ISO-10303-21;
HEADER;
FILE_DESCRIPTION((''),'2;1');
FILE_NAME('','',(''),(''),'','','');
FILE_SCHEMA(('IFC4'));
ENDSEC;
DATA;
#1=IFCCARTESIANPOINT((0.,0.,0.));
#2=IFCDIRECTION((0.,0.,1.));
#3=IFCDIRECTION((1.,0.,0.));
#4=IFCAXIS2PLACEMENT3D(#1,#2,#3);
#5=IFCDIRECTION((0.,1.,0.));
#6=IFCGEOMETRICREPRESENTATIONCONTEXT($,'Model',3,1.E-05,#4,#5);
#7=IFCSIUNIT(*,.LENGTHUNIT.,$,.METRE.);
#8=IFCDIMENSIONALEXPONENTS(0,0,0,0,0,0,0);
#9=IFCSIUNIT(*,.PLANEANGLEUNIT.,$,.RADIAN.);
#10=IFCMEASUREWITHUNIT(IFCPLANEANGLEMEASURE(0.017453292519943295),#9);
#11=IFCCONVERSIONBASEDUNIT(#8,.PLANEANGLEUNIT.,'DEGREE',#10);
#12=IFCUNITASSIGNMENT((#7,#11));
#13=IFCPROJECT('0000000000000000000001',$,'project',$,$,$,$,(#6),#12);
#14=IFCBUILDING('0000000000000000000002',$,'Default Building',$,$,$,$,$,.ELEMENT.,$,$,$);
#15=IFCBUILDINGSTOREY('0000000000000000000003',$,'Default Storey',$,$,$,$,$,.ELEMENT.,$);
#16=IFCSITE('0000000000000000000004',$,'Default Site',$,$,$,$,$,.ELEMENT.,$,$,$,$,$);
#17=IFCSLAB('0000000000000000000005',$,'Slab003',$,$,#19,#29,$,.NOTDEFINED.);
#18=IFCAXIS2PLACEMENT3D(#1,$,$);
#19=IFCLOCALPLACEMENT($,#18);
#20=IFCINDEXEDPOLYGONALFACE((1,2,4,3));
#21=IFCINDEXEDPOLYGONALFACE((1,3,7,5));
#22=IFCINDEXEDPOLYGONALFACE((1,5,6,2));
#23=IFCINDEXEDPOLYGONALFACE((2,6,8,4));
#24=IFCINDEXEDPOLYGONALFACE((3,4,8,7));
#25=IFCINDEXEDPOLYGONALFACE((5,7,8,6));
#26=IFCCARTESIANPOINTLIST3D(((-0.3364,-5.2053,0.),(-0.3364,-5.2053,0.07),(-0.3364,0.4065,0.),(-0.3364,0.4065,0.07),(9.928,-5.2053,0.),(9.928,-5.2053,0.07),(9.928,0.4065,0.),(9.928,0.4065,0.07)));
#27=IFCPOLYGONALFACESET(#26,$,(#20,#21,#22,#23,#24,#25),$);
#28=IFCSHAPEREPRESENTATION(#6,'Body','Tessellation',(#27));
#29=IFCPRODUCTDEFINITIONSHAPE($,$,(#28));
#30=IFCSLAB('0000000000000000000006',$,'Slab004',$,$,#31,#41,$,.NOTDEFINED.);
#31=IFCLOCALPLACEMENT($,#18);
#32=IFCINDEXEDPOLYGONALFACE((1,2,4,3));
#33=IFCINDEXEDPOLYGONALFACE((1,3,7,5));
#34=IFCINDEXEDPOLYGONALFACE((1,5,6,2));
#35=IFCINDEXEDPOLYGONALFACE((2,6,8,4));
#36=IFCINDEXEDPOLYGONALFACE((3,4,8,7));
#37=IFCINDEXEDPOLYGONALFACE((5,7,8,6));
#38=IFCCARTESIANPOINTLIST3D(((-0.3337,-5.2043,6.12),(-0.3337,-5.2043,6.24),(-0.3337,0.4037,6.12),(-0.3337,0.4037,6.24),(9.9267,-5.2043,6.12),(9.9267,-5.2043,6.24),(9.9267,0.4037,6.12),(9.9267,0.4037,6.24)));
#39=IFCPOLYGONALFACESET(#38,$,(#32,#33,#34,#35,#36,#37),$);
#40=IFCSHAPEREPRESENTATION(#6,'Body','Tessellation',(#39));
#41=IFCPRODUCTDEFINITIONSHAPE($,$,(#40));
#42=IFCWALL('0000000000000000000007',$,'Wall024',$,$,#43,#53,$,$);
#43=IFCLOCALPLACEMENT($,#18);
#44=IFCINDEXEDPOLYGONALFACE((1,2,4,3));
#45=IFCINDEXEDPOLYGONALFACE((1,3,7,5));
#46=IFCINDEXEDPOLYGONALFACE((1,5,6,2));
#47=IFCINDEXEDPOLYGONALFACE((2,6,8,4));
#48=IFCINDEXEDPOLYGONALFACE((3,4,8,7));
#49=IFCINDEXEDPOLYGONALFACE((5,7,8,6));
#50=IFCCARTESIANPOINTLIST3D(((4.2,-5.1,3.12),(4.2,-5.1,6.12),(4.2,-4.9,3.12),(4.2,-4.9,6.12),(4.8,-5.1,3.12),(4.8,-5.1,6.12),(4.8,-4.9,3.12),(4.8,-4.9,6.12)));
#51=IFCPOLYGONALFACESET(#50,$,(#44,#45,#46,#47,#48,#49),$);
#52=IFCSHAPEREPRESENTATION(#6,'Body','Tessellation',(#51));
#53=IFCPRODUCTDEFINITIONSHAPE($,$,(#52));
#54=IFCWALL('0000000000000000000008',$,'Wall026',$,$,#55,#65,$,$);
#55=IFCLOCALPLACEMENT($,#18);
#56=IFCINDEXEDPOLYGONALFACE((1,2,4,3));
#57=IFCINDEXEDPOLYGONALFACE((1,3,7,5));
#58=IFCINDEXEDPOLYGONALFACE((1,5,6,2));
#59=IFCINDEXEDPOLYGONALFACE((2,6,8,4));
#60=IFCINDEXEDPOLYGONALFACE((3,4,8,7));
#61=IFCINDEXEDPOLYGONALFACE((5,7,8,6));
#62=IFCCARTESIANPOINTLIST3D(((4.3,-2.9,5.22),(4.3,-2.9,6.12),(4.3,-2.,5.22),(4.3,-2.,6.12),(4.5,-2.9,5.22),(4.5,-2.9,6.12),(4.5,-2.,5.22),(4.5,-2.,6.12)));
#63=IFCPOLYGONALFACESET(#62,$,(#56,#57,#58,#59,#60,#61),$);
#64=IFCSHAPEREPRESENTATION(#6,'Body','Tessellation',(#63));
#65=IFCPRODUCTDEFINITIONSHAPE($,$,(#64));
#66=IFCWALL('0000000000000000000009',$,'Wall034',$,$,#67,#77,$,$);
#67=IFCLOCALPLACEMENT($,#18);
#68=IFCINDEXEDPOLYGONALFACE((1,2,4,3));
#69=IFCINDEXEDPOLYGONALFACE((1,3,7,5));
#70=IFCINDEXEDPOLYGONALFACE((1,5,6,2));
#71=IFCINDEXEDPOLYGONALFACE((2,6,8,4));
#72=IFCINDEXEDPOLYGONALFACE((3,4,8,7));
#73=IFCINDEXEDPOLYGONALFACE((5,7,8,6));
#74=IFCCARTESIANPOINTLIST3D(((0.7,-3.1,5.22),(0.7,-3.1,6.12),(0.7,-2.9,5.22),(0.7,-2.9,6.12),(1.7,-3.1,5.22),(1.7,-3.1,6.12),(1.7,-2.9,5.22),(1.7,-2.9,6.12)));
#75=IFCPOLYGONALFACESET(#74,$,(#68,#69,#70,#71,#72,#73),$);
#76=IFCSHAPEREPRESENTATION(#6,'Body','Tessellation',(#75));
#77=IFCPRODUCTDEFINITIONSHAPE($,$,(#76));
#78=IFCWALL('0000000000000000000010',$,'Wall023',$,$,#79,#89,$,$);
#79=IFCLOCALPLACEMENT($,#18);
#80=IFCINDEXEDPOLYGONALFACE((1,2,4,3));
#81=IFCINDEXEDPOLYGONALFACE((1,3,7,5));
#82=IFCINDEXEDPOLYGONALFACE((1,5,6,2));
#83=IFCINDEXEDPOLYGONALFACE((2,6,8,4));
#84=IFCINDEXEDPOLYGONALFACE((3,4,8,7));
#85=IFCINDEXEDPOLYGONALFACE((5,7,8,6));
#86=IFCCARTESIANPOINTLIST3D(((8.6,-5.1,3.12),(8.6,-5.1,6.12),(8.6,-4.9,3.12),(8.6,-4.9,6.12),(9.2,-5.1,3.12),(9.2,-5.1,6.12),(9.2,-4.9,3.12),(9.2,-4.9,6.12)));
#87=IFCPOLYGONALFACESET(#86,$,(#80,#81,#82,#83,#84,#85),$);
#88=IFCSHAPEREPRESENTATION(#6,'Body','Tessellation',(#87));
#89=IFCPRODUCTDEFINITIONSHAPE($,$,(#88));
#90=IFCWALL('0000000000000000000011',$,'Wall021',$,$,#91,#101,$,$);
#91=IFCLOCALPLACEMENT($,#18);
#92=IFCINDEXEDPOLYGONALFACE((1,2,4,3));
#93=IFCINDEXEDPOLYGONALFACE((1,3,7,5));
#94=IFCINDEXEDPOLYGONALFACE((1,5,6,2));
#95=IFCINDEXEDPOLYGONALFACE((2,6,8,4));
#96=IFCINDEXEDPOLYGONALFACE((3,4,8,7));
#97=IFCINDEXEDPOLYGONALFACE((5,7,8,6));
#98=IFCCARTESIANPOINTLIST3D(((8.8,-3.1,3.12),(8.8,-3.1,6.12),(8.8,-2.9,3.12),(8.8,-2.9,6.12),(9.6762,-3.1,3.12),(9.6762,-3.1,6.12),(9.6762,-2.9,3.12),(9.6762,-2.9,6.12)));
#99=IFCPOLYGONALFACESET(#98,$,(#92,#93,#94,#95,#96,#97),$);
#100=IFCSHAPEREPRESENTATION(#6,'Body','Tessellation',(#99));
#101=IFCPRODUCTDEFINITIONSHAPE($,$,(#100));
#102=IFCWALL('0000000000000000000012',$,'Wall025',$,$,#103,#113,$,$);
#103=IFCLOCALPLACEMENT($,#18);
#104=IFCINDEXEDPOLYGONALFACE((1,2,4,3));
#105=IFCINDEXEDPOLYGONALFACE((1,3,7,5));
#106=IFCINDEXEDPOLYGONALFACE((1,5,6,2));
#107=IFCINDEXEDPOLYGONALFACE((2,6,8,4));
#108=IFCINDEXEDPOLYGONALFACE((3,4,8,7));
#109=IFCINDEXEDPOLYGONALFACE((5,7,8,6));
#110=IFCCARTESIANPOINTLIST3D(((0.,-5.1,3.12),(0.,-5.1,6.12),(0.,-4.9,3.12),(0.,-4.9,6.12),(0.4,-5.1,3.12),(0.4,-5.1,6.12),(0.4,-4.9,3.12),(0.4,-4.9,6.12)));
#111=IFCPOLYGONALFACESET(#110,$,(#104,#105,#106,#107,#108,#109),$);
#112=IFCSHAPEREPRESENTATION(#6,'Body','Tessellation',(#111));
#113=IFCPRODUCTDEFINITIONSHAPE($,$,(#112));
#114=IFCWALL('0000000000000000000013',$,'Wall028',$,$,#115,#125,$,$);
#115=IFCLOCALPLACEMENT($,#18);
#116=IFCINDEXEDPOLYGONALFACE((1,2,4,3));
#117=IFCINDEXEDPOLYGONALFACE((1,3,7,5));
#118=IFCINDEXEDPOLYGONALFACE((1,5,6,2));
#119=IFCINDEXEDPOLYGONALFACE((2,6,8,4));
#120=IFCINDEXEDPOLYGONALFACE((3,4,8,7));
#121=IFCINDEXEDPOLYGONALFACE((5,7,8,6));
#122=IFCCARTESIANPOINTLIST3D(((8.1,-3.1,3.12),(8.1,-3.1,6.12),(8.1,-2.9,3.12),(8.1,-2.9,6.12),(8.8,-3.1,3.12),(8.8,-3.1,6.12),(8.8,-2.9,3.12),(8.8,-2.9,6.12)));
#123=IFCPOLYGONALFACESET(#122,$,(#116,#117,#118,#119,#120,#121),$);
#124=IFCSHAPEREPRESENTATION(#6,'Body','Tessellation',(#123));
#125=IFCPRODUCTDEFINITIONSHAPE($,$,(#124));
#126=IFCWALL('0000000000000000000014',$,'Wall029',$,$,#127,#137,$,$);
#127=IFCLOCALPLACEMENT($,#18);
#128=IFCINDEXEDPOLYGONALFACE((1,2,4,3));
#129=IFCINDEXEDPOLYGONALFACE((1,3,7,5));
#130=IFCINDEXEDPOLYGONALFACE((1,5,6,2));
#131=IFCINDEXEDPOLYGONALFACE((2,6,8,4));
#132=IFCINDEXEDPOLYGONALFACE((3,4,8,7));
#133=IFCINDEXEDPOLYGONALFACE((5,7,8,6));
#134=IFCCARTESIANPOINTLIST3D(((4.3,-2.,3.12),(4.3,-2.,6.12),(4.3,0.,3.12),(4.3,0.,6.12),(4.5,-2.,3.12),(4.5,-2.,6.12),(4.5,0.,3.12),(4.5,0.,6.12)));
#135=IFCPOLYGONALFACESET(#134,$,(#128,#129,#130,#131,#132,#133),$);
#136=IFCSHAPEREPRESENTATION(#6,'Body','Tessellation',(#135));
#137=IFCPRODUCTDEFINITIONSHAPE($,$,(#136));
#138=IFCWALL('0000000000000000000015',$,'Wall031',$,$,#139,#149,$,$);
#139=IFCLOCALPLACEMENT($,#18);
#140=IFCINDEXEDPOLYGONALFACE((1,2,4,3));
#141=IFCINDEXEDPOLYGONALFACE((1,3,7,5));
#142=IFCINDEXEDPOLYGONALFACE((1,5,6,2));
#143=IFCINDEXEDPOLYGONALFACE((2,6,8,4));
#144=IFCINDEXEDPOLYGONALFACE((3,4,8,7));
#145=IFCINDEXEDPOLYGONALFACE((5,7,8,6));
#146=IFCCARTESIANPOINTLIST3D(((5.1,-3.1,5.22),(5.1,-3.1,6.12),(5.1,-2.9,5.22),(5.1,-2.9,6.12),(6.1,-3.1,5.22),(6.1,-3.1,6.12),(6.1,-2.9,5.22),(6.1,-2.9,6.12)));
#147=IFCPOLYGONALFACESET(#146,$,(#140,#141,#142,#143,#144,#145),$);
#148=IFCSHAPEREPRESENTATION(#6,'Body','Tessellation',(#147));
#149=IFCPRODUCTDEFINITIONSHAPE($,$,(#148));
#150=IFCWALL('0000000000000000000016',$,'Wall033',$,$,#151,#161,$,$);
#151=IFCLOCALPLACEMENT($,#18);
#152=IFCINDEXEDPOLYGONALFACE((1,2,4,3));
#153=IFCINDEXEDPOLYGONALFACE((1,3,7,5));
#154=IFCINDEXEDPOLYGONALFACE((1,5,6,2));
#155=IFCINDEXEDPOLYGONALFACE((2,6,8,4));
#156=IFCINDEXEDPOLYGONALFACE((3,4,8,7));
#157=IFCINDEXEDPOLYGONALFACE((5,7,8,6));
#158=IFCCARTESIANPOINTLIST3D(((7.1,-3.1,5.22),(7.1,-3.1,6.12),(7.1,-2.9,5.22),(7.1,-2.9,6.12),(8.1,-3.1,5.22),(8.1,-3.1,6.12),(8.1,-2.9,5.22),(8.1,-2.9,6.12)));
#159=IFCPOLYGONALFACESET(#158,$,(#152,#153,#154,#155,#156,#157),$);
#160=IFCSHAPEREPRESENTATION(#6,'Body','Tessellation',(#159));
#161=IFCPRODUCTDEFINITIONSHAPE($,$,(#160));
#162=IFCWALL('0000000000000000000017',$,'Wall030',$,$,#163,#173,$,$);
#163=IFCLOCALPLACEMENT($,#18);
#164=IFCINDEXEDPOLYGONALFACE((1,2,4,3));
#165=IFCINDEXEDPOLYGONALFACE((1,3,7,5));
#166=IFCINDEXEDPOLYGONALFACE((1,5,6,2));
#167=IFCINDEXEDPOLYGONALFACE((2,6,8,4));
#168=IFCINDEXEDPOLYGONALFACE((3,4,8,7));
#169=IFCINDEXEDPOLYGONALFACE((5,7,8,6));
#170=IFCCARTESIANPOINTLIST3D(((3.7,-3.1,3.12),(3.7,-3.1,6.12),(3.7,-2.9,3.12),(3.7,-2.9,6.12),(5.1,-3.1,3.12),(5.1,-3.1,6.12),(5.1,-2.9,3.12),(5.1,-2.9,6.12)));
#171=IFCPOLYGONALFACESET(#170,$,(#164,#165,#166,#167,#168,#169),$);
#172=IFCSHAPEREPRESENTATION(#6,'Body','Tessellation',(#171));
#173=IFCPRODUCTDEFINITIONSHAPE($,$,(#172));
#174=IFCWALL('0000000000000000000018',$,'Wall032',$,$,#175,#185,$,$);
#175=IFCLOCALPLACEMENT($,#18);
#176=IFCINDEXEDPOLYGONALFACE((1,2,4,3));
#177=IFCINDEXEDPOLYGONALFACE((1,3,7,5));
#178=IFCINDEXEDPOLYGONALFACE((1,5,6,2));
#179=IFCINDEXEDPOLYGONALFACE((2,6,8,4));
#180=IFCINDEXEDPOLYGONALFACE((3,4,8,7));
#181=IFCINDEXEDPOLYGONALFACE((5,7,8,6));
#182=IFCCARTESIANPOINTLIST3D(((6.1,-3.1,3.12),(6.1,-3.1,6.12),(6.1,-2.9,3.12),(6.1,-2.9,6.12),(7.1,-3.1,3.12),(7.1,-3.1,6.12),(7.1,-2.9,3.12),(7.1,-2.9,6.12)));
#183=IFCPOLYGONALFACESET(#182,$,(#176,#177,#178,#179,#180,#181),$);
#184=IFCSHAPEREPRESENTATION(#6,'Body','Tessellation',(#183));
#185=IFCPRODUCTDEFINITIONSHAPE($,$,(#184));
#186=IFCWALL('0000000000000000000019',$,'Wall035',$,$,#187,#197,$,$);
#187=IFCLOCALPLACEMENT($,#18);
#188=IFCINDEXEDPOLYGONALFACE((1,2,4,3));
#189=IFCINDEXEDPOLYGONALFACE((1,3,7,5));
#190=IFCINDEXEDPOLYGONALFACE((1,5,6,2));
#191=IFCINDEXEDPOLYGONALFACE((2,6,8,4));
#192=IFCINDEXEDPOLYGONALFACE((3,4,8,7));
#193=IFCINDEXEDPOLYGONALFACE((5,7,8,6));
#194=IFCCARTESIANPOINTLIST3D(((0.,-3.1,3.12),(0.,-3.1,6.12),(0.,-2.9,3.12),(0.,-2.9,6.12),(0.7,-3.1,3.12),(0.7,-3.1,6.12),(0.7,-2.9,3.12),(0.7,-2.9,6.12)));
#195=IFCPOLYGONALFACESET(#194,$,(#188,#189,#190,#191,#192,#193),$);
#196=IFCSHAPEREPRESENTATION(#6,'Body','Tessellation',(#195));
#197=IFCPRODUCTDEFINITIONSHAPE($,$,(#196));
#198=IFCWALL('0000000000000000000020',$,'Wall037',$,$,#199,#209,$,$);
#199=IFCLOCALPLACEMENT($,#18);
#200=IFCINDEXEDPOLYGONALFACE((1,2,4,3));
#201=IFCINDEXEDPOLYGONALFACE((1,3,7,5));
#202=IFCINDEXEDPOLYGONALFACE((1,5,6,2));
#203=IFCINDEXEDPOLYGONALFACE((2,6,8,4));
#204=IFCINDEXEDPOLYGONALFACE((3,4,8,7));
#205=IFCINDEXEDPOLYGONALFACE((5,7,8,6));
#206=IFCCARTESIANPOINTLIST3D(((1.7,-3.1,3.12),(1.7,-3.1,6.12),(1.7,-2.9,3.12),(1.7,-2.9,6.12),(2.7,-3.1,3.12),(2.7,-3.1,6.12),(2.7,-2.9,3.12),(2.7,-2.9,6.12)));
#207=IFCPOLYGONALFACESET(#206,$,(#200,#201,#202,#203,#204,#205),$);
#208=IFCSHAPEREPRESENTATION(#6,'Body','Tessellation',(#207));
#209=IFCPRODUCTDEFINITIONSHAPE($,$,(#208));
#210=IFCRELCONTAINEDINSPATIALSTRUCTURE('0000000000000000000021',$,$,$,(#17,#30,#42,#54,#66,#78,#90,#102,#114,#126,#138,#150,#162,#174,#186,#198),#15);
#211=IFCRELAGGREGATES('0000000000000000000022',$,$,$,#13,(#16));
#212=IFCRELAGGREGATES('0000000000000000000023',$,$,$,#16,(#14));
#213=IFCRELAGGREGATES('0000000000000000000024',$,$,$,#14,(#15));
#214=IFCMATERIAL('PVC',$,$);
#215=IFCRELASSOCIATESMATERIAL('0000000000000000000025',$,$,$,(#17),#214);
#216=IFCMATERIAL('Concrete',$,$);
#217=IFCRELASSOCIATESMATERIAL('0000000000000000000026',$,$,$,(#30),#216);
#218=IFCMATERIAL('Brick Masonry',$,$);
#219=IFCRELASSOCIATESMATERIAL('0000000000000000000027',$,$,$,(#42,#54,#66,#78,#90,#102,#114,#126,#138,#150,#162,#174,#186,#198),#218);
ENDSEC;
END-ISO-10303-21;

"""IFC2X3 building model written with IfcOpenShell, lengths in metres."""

from ifc_helpers import new_model, entity, si_unit, converted_unit, direction, frame, frame_2d, origin_with_axes, place, context, project, spatial, rectangle, extrude, material, element, save


model = new_model("IFC2X3")

# Units and contexts
model_context = context("Model", 3, precision=1e-05, world=origin_with_axes(), true_north=direction((0.0, 1.0, 0.0)))
ifc_project = project(units=[si_unit("LENGTHUNIT", "METRE"), converted_unit("PLANEANGLEUNIT", "DEGREE", entity("IfcPlaneAngleMeasure", 0.017453292519943295), si_unit("PLANEANGLEUNIT", "RADIAN"), dimensions=[0, 0, 0, 0, 0, 0, 0])], contexts=[model_context])

# Site, building, storey
site = spatial("IfcSite", under=ifc_project, Name="Default Site", CompositionType="ELEMENT")
building = spatial("IfcBuilding", under=site, Name="Default Building", CompositionType="ELEMENT")
storey = spatial("IfcBuildingStorey", under=building, Name="Default Storey", CompositionType="ELEMENT")

# Slabs
ifc_material_1 = material(Name="PVC")
placement = place(None, origin_with_axes())
element("IfcSlab", 1, at=placement, inside=storey, material=ifc_material_1, Name="Slab003", PredefinedType="NOTDEFINED", context=model_context, shape_type="SweptSolid", body=[
    extrude(rectangle(XDim=10.2644, YDim=5.6118, at=frame_2d((0.0, 0.0), x_axis=(1.0, 0.0, 0.0))), frame((4.7958, -2.3994, 0.0), z_axis=(0.0, 0.0, 1.0), x_axis=(1.0, 0.0, 0.0)), (0.0, 0.0, 1.0), 0.07),
])
ifc_material_2 = material(Name="Concrete")
element("IfcSlab", 2, at=placement, inside=storey, material=ifc_material_2, Name="Slab004", PredefinedType="NOTDEFINED", context=model_context, shape_type="SweptSolid", body=[
    extrude(rectangle(XDim=10.2604, YDim=5.608, at=frame_2d((0.0, 0.0), x_axis=(1.0, 0.0, 0.0))), frame((4.7965, -2.4003, 6.12), z_axis=(0.0, 0.0, 1.0), x_axis=(1.0, 0.0, 0.0)), (0.0, 0.0, 1.0), 0.12),
])

# Walls
ifc_material_3 = material(Name="Brick Masonry")
element("IfcWall", 3, at=placement, inside=storey, material=ifc_material_3, Name="Wall024", context=model_context, shape_type="SweptSolid", body=[
    extrude(rectangle(XDim=0.6, YDim=0.2, at=frame_2d((0.0, 0.0), x_axis=(1.0, 0.0, 0.0))), frame((4.5, -5.0, 3.12), z_axis=(0.0, 0.0, 1.0), x_axis=(1.0, 0.0, 0.0)), (0.0, 0.0, 1.0), 3.0),
])
element("IfcWall", 4, at=placement, inside=storey, material=ifc_material_3, Name="Wall026", context=model_context, shape_type="SweptSolid", body=[
    extrude(rectangle(XDim=0.9, YDim=0.2, at=frame_2d((0.0, 0.0), x_axis=(0.0, -1.0, 0.0))), frame((4.4, -2.45, 5.22), z_axis=(0.0, 0.0, 1.0), x_axis=(1.0, 0.0, 0.0)), (0.0, 0.0, 1.0), 0.9),
])
element("IfcWall", 5, at=placement, inside=storey, material=ifc_material_3, Name="Wall034", context=model_context, shape_type="SweptSolid", body=[
    extrude(rectangle(XDim=1.0, YDim=0.2, at=frame_2d((0.0, 0.0), x_axis=(1.0, 0.0, 0.0))), frame((1.2, -3.0, 5.22), z_axis=(0.0, 0.0, 1.0), x_axis=(1.0, 0.0, 0.0)), (0.0, 0.0, 1.0), 0.9),
])
element("IfcWall", 6, at=placement, inside=storey, material=ifc_material_3, Name="Wall023", context=model_context, shape_type="SweptSolid", body=[
    extrude(rectangle(XDim=0.6, YDim=0.2, at=frame_2d((0.0, 0.0), x_axis=(1.0, 0.0, 0.0))), frame((8.9, -5.0, 3.12), z_axis=(0.0, 0.0, 1.0), x_axis=(1.0, 0.0, 0.0)), (0.0, 0.0, 1.0), 3.0),
])
element("IfcWall", 7, at=placement, inside=storey, material=ifc_material_3, Name="Wall021", context=model_context, shape_type="SweptSolid", body=[
    extrude(rectangle(XDim=0.8762, YDim=0.2, at=frame_2d((0.0, 0.0), x_axis=(1.0, 0.0, 0.0))), frame((9.2381, -3.0, 3.12), z_axis=(0.0, 0.0, 1.0), x_axis=(1.0, 0.0, 0.0)), (0.0, 0.0, 1.0), 3.0),
])
element("IfcWall", 8, at=placement, inside=storey, material=ifc_material_3, Name="Wall025", context=model_context, shape_type="SweptSolid", body=[
    extrude(rectangle(XDim=0.4, YDim=0.2, at=frame_2d((0.0, 0.0), x_axis=(1.0, 0.0, 0.0))), frame((0.2, -5.0, 3.12), z_axis=(0.0, 0.0, 1.0), x_axis=(1.0, 0.0, 0.0)), (0.0, 0.0, 1.0), 3.0),
])
element("IfcWall", 9, at=placement, inside=storey, material=ifc_material_3, Name="Wall028", context=model_context, shape_type="SweptSolid", body=[
    extrude(rectangle(XDim=0.7, YDim=0.2, at=frame_2d((0.0, 0.0), x_axis=(1.0, 0.0, 0.0))), frame((8.45, -3.0, 3.12), z_axis=(0.0, 0.0, 1.0), x_axis=(1.0, 0.0, 0.0)), (0.0, 0.0, 1.0), 3.0),
])
element("IfcWall", 10, at=placement, inside=storey, material=ifc_material_3, Name="Wall029", context=model_context, shape_type="SweptSolid", body=[
    extrude(rectangle(XDim=2.0, YDim=0.2, at=frame_2d((0.0, 0.0), x_axis=(0.0, -1.0, 0.0))), frame((4.4, -1.0, 3.12), z_axis=(0.0, 0.0, 1.0), x_axis=(1.0, 0.0, 0.0)), (0.0, 0.0, 1.0), 3.0),
])
element("IfcWall", 11, at=placement, inside=storey, material=ifc_material_3, Name="Wall031", context=model_context, shape_type="SweptSolid", body=[
    extrude(rectangle(XDim=1.0, YDim=0.2, at=frame_2d((0.0, 0.0), x_axis=(1.0, 0.0, 0.0))), frame((5.6, -3.0, 5.22), z_axis=(0.0, 0.0, 1.0), x_axis=(1.0, 0.0, 0.0)), (0.0, 0.0, 1.0), 0.9),
])
element("IfcWall", 12, at=placement, inside=storey, material=ifc_material_3, Name="Wall033", context=model_context, shape_type="SweptSolid", body=[
    extrude(rectangle(XDim=1.0, YDim=0.2, at=frame_2d((0.0, 0.0), x_axis=(1.0, 0.0, 0.0))), frame((7.6, -3.0, 5.22), z_axis=(0.0, 0.0, 1.0), x_axis=(1.0, 0.0, 0.0)), (0.0, 0.0, 1.0), 0.9),
])
element("IfcWall", 13, at=placement, inside=storey, material=ifc_material_3, Name="Wall030", context=model_context, shape_type="SweptSolid", body=[
    extrude(rectangle(XDim=1.4, YDim=0.2, at=frame_2d((0.0, 0.0), x_axis=(1.0, 0.0, 0.0))), frame((4.4, -3.0, 3.12), z_axis=(0.0, 0.0, 1.0), x_axis=(1.0, 0.0, 0.0)), (0.0, 0.0, 1.0), 3.0),
])
element("IfcWall", 14, at=placement, inside=storey, material=ifc_material_3, Name="Wall032", context=model_context, shape_type="SweptSolid", body=[
    extrude(rectangle(XDim=1.0, YDim=0.2, at=frame_2d((0.0, 0.0), x_axis=(1.0, 0.0, 0.0))), frame((6.6, -3.0, 3.12), z_axis=(0.0, 0.0, 1.0), x_axis=(1.0, 0.0, 0.0)), (0.0, 0.0, 1.0), 3.0),
])
element("IfcWall", 15, at=placement, inside=storey, material=ifc_material_3, Name="Wall035", context=model_context, shape_type="SweptSolid", body=[
    extrude(rectangle(XDim=0.7, YDim=0.2, at=frame_2d((0.0, 0.0), x_axis=(1.0, 0.0, 0.0))), frame((0.35, -3.0, 3.12), z_axis=(0.0, 0.0, 1.0), x_axis=(1.0, 0.0, 0.0)), (0.0, 0.0, 1.0), 3.0),
])
element("IfcWall", 16, at=placement, inside=storey, material=ifc_material_3, Name="Wall037", context=model_context, shape_type="SweptSolid", body=[
    extrude(rectangle(XDim=1.0, YDim=0.2, at=frame_2d((0.0, 0.0), x_axis=(1.0, 0.0, 0.0))), frame((2.2, -3.0, 3.12), z_axis=(0.0, 0.0, 1.0), x_axis=(1.0, 0.0, 0.0)), (0.0, 0.0, 1.0), 3.0),
])

save(model, "model.ifc")
